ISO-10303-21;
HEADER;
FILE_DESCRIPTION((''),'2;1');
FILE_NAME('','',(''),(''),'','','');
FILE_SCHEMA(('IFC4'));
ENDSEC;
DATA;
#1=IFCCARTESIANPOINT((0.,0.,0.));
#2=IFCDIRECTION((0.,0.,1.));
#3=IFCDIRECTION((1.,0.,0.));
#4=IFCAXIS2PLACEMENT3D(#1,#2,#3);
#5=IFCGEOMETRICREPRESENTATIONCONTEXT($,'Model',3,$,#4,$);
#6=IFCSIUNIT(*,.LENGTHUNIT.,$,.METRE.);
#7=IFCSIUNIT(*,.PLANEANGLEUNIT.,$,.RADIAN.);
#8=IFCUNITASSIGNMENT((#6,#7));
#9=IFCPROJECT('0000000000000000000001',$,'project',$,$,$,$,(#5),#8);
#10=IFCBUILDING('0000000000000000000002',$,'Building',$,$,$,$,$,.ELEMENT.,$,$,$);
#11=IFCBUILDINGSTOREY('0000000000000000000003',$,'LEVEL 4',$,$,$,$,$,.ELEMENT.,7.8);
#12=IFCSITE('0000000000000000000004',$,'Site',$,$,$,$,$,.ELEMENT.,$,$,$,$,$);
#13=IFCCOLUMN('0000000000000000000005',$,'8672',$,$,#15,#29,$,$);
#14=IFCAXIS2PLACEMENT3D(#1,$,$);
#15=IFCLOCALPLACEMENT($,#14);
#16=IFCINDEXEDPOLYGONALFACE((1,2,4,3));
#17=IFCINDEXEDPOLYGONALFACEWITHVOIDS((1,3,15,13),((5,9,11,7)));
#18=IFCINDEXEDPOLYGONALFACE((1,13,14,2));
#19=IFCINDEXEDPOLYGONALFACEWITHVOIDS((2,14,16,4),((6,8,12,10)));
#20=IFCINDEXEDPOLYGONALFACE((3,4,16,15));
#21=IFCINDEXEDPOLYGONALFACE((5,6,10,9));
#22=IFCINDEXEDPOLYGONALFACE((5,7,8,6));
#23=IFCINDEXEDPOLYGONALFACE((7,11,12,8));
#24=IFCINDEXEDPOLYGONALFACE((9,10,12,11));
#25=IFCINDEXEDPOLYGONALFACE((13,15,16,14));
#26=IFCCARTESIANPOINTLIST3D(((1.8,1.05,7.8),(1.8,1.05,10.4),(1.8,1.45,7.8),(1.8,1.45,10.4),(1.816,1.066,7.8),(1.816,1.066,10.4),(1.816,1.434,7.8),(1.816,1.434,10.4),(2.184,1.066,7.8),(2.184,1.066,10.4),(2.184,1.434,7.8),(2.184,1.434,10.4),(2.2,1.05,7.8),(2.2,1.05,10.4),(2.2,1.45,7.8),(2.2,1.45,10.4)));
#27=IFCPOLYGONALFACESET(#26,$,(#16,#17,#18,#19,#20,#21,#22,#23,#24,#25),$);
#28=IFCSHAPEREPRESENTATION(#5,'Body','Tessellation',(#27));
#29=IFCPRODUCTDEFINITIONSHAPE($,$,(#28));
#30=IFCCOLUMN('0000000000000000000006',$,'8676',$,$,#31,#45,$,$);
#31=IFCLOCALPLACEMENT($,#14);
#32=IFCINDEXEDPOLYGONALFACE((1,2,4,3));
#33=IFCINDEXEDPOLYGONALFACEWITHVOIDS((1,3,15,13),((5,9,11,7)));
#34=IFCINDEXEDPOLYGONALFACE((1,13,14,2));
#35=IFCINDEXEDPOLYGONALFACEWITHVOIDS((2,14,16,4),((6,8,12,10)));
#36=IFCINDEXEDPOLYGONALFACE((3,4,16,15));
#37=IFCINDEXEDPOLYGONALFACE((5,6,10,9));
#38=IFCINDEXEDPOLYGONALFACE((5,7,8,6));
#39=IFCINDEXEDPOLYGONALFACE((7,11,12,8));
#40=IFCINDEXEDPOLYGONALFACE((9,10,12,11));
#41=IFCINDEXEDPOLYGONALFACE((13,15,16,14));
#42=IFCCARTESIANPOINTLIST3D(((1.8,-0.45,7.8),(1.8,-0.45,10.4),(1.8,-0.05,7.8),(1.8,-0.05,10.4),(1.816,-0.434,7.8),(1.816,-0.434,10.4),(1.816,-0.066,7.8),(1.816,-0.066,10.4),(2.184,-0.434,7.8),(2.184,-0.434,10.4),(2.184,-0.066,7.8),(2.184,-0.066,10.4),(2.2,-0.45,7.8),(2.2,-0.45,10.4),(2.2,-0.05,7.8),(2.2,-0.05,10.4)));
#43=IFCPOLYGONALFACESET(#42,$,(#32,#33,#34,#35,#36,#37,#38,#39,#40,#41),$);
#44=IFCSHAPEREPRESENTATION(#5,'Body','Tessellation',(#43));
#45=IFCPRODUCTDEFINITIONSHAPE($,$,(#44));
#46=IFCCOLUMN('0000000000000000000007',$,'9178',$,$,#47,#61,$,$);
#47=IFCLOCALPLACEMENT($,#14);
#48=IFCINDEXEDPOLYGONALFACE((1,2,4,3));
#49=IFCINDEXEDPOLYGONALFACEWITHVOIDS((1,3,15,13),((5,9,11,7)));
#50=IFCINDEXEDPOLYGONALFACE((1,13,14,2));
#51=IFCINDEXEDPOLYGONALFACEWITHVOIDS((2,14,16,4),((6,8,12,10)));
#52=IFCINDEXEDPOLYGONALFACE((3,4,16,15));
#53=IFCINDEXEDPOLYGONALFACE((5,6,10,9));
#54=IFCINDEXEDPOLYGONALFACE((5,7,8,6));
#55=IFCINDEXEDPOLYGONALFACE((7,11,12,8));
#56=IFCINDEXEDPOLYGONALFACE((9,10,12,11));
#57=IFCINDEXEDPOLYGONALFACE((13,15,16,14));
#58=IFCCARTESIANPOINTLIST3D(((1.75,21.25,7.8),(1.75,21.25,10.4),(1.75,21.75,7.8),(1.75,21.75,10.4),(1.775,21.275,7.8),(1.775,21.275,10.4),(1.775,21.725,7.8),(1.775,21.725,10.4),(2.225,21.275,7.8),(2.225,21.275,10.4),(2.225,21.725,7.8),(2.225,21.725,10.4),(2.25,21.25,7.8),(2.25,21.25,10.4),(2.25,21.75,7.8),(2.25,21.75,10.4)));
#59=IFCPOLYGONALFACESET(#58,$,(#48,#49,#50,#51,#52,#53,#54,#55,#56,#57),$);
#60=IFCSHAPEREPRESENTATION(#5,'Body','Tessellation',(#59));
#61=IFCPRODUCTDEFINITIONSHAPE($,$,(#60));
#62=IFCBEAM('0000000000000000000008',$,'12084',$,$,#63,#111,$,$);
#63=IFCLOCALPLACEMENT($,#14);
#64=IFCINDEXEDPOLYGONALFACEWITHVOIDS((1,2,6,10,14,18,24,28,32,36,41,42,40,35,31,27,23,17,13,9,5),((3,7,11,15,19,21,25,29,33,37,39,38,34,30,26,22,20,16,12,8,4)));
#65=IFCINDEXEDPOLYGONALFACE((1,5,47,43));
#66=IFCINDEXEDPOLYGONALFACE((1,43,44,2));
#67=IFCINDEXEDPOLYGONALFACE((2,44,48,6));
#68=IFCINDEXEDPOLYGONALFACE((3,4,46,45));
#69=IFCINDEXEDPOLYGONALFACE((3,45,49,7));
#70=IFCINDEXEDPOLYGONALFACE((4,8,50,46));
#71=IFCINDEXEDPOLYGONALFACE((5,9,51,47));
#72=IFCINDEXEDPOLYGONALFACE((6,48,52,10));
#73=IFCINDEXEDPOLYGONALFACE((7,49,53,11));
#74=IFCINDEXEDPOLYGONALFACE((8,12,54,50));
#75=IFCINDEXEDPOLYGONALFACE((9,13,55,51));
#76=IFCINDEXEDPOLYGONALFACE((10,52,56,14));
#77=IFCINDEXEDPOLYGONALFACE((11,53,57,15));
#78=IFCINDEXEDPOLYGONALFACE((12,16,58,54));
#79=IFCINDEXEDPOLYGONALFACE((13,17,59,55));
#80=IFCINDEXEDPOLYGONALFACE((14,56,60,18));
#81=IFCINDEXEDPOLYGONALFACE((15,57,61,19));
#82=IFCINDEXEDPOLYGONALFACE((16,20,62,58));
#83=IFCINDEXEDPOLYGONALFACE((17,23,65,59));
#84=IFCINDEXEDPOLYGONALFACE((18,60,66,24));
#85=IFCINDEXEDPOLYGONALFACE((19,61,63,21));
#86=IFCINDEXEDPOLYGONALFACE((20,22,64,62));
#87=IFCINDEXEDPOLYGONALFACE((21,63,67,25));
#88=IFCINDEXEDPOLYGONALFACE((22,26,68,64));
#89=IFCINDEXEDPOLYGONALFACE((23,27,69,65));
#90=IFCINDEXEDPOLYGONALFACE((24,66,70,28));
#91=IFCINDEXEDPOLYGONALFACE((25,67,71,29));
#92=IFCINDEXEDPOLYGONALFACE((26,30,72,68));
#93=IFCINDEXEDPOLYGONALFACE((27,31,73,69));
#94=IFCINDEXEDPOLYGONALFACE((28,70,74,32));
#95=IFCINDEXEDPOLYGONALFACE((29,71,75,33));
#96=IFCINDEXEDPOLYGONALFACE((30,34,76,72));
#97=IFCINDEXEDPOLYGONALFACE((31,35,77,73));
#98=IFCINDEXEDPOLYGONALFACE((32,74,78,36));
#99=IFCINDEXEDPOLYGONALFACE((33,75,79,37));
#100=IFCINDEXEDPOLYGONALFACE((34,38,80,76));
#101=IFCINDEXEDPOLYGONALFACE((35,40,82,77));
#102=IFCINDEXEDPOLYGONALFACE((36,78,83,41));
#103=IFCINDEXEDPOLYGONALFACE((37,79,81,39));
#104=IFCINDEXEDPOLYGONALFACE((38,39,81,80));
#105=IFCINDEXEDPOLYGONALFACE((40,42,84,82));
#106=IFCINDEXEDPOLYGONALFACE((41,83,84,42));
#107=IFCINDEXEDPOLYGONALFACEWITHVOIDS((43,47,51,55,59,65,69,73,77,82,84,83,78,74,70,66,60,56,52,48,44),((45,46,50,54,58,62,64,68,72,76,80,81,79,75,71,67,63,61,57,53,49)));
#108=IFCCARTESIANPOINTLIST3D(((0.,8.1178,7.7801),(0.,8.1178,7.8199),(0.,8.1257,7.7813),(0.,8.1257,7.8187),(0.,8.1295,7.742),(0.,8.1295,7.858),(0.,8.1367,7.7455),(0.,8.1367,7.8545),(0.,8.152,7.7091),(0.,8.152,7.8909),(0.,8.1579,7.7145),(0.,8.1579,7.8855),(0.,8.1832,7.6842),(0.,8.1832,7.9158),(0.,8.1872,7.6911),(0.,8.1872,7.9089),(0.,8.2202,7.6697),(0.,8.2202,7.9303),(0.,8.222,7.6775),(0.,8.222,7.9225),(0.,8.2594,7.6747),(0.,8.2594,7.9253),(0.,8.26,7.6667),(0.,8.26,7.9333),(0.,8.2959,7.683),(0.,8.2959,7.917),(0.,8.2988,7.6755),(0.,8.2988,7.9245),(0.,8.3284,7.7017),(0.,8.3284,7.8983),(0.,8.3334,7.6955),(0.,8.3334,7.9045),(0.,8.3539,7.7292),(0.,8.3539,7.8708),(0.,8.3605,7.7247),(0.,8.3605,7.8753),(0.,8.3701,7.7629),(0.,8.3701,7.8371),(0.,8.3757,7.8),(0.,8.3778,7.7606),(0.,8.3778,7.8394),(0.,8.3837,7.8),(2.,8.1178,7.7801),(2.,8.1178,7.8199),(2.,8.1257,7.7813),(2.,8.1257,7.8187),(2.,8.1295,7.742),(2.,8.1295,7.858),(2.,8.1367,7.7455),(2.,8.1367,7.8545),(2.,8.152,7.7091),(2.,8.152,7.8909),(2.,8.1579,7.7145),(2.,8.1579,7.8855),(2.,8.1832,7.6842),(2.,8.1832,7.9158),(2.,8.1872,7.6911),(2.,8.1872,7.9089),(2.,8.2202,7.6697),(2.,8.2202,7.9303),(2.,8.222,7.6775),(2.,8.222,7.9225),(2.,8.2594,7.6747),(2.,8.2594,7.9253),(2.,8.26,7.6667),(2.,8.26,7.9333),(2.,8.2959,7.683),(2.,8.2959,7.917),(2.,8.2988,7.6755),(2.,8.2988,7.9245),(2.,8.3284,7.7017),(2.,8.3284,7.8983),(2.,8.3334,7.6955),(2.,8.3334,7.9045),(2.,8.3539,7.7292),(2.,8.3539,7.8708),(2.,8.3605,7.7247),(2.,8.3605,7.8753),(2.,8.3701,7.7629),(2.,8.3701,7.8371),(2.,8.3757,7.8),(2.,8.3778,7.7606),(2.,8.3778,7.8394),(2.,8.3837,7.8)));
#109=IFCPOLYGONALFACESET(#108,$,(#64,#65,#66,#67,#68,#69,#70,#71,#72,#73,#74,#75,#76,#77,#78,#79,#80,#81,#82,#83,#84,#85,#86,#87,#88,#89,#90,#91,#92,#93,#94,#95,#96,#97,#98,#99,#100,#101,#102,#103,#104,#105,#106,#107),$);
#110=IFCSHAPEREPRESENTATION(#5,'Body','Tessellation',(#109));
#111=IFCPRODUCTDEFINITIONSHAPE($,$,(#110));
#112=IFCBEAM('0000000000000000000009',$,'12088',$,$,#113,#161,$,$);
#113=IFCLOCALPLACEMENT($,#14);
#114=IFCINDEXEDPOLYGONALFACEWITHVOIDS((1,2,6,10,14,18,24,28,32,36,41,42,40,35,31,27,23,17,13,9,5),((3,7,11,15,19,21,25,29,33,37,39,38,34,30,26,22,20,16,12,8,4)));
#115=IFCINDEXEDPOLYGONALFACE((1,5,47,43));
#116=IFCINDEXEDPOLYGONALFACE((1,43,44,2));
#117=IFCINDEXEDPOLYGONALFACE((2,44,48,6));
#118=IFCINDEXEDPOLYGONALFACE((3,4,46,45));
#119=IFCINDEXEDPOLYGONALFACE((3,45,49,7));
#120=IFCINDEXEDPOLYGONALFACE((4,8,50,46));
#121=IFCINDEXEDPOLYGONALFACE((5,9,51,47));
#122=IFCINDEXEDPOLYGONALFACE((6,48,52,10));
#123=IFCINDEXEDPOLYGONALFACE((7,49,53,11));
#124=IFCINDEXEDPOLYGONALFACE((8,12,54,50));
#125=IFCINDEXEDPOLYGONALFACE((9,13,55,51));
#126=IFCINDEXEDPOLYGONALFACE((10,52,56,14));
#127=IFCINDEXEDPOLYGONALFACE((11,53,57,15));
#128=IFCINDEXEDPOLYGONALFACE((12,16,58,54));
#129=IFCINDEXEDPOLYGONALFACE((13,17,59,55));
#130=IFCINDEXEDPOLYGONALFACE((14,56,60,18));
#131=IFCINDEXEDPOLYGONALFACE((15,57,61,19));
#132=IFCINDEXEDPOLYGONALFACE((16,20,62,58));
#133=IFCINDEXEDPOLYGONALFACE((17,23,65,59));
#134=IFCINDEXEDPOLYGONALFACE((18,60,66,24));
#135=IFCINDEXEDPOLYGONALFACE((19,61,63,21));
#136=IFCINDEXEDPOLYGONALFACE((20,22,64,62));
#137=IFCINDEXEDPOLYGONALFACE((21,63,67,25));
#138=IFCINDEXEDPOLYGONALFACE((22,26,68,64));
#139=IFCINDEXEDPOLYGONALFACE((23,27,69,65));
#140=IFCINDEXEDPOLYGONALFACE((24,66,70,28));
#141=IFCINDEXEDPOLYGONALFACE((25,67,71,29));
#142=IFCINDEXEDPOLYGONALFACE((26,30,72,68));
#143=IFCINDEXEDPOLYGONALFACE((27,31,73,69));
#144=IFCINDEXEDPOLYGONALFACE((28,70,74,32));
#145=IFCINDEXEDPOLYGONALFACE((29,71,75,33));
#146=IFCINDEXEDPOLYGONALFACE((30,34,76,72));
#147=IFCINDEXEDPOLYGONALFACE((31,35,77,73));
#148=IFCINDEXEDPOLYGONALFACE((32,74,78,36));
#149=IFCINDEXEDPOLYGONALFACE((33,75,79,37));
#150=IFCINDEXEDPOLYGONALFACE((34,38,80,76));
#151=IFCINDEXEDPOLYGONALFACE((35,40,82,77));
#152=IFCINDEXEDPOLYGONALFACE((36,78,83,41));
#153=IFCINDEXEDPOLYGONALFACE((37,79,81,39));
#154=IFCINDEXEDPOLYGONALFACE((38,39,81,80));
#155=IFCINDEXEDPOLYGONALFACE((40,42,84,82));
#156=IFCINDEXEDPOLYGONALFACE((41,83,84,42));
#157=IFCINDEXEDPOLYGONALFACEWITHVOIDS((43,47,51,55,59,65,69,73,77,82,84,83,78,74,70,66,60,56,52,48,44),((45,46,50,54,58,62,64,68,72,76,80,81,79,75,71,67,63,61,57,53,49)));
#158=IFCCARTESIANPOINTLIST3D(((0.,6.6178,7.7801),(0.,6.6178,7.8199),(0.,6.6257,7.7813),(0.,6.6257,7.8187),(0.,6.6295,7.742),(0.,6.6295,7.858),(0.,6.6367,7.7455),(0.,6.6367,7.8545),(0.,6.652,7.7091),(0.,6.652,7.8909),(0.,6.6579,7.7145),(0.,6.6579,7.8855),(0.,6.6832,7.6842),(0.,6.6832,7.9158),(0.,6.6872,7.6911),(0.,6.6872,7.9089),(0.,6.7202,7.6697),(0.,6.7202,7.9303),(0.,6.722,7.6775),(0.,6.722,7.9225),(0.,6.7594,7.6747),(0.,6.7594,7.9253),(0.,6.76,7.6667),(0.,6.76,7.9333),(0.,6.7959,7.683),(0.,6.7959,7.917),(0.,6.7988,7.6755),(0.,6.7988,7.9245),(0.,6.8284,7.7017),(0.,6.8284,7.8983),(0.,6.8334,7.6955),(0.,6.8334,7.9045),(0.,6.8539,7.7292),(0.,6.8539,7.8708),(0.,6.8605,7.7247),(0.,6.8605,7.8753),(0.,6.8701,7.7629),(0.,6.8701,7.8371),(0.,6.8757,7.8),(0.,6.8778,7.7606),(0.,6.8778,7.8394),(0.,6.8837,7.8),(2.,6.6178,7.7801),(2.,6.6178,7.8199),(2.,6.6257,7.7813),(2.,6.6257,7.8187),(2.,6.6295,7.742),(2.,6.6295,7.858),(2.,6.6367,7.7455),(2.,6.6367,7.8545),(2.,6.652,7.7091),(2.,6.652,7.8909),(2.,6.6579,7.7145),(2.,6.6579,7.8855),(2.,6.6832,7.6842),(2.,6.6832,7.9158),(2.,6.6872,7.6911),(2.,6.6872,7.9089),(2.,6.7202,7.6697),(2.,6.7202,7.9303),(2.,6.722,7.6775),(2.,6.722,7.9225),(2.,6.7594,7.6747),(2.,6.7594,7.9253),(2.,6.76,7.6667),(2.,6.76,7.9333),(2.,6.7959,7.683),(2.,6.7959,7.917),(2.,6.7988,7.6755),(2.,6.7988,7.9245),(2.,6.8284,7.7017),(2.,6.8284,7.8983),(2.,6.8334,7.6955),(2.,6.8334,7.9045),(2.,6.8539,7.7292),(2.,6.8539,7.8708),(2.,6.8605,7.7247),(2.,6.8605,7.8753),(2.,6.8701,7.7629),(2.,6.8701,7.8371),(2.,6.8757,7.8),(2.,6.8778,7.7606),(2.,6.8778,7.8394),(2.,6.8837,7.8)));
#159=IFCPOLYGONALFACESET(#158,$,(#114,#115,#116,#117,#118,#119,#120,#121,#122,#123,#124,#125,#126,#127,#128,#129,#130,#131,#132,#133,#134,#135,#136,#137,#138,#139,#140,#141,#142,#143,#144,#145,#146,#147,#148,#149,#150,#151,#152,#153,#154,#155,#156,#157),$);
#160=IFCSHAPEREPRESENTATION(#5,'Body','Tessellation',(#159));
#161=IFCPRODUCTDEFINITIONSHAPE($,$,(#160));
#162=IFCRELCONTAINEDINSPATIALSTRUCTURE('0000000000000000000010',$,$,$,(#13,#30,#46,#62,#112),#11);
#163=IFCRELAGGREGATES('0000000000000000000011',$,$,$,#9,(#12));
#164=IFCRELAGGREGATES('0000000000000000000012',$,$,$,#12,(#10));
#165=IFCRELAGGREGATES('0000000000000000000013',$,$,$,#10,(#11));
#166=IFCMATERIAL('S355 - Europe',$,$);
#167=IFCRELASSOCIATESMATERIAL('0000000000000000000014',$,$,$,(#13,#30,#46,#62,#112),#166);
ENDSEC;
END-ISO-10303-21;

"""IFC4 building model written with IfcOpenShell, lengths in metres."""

from ifc_helpers import new_model, si_unit, frame, origin_with_axes, origin_2d_with_axis, place, context, project, spatial, hollow_rectangle, hollow_circle, extrude, material, material_profile, profile_set, profile_usage, element, save


model = new_model("IFC4")

# Units and contexts
model_context = context("Model", 3, world=origin_with_axes())
ifc_project = project(units=[si_unit("LENGTHUNIT", "METRE"), si_unit("PLANEANGLEUNIT", "RADIAN")], contexts=[model_context])

# Site, building, storey
site = spatial("IfcSite", under=ifc_project, Name="Site", CompositionType="ELEMENT")
building = spatial("IfcBuilding", under=site, Name="Building", CompositionType="ELEMENT")
storey = spatial("IfcBuildingStorey", under=building, Name="LEVEL 4", CompositionType="ELEMENT", Elevation=7.8)

# Columns
ifc_material = material(Name="S355 - Europe")
ifc_material_profile_1 = material_profile(ifc_material, hollow_rectangle(XDim=0.4, YDim=0.4, WallThickness=0.016, at=origin_2d_with_axis()))
ifc_profile_set_1 = profile_set([ifc_material_profile_1])
ifc_profile_usage_1 = profile_usage(ifc_profile_set_1, cardinal=10)
column_1_placement = place(None, frame((2.0, 1.25, 7.8), z_axis=(0.0, 0.0, 1.0), x_axis=(0.0, -1.0, 0.0)))
element("IfcColumn", 1, at=column_1_placement, inside=storey, material=ifc_profile_usage_1, Name="8672", context=model_context, shape_type="SweptSolid", body=[
    extrude(hollow_rectangle(XDim=0.4, YDim=0.4, WallThickness=0.016, at=origin_2d_with_axis()), origin_with_axes(), (0.0, 0.0, 1.0), 2.6),
])
ifc_material_profile_2 = material_profile(ifc_material, hollow_rectangle(XDim=0.4, YDim=0.4, WallThickness=0.016, at=origin_2d_with_axis()))
ifc_profile_set_2 = profile_set([ifc_material_profile_2])
ifc_profile_usage_2 = profile_usage(ifc_profile_set_2, cardinal=10)
column_2_placement = place(None, frame((2.0, -0.25, 7.8), z_axis=(0.0, 0.0, 1.0), x_axis=(0.0, -1.0, 0.0)))
element("IfcColumn", 2, at=column_2_placement, inside=storey, material=ifc_profile_usage_2, Name="8676", context=model_context, shape_type="SweptSolid", body=[
    extrude(hollow_rectangle(XDim=0.4, YDim=0.4, WallThickness=0.016, at=origin_2d_with_axis()), origin_with_axes(), (0.0, 0.0, 1.0), 2.6),
])
ifc_material_profile_3 = material_profile(ifc_material, hollow_rectangle(XDim=0.5, YDim=0.5, WallThickness=0.025, at=origin_2d_with_axis()))
ifc_profile_set_3 = profile_set([ifc_material_profile_3])
ifc_profile_usage_3 = profile_usage(ifc_profile_set_3, cardinal=10)
column_3_placement = place(None, frame((2.0, 21.5, 7.8), z_axis=(0.0, 0.0, 1.0), x_axis=(1.0, 0.0, 0.0)))
element("IfcColumn", 3, at=column_3_placement, inside=storey, material=ifc_profile_usage_3, Name="9178", context=model_context, shape_type="SweptSolid", body=[
    extrude(hollow_rectangle(XDim=0.5, YDim=0.5, WallThickness=0.025, at=origin_2d_with_axis()), origin_with_axes(), (0.0, 0.0, 1.0), 2.6),
])

# Beams
ifc_material_profile_4 = material_profile(ifc_material, hollow_circle(Radius=0.1337, WallThickness=0.008, at=origin_2d_with_axis()))
ifc_profile_set_4 = profile_set([ifc_material_profile_4])
ifc_profile_usage_4 = profile_usage(ifc_profile_set_4, cardinal=10)
beam_1_placement = place(None, frame((0.0, 8.25, 7.8), z_axis=(1.0, 0.0, 0.0), x_axis=(0.0, 1.0, 0.0)))
element("IfcBeam", 4, at=beam_1_placement, inside=storey, material=ifc_profile_usage_4, Name="12084", context=model_context, shape_type="SweptSolid", body=[
    extrude(hollow_circle(Radius=0.1337, WallThickness=0.008, at=origin_2d_with_axis()), origin_with_axes(), (0.0, 0.0, 1.0), 2.0),
])
ifc_material_profile_5 = material_profile(ifc_material, hollow_circle(Radius=0.1337, WallThickness=0.008, at=origin_2d_with_axis()))
ifc_profile_set_5 = profile_set([ifc_material_profile_5])
ifc_profile_usage_5 = profile_usage(ifc_profile_set_5, cardinal=10)
beam_2_placement = place(None, frame((0.0, 6.75, 7.8), z_axis=(1.0, 0.0, 0.0), x_axis=(0.0, 1.0, 0.0)))
element("IfcBeam", 5, at=beam_2_placement, inside=storey, material=ifc_profile_usage_5, Name="12088", context=model_context, shape_type="SweptSolid", body=[
    extrude(hollow_circle(Radius=0.1337, WallThickness=0.008, at=origin_2d_with_axis()), origin_with_axes(), (0.0, 0.0, 1.0), 2.0),
])

save(model, "model.ifc")
